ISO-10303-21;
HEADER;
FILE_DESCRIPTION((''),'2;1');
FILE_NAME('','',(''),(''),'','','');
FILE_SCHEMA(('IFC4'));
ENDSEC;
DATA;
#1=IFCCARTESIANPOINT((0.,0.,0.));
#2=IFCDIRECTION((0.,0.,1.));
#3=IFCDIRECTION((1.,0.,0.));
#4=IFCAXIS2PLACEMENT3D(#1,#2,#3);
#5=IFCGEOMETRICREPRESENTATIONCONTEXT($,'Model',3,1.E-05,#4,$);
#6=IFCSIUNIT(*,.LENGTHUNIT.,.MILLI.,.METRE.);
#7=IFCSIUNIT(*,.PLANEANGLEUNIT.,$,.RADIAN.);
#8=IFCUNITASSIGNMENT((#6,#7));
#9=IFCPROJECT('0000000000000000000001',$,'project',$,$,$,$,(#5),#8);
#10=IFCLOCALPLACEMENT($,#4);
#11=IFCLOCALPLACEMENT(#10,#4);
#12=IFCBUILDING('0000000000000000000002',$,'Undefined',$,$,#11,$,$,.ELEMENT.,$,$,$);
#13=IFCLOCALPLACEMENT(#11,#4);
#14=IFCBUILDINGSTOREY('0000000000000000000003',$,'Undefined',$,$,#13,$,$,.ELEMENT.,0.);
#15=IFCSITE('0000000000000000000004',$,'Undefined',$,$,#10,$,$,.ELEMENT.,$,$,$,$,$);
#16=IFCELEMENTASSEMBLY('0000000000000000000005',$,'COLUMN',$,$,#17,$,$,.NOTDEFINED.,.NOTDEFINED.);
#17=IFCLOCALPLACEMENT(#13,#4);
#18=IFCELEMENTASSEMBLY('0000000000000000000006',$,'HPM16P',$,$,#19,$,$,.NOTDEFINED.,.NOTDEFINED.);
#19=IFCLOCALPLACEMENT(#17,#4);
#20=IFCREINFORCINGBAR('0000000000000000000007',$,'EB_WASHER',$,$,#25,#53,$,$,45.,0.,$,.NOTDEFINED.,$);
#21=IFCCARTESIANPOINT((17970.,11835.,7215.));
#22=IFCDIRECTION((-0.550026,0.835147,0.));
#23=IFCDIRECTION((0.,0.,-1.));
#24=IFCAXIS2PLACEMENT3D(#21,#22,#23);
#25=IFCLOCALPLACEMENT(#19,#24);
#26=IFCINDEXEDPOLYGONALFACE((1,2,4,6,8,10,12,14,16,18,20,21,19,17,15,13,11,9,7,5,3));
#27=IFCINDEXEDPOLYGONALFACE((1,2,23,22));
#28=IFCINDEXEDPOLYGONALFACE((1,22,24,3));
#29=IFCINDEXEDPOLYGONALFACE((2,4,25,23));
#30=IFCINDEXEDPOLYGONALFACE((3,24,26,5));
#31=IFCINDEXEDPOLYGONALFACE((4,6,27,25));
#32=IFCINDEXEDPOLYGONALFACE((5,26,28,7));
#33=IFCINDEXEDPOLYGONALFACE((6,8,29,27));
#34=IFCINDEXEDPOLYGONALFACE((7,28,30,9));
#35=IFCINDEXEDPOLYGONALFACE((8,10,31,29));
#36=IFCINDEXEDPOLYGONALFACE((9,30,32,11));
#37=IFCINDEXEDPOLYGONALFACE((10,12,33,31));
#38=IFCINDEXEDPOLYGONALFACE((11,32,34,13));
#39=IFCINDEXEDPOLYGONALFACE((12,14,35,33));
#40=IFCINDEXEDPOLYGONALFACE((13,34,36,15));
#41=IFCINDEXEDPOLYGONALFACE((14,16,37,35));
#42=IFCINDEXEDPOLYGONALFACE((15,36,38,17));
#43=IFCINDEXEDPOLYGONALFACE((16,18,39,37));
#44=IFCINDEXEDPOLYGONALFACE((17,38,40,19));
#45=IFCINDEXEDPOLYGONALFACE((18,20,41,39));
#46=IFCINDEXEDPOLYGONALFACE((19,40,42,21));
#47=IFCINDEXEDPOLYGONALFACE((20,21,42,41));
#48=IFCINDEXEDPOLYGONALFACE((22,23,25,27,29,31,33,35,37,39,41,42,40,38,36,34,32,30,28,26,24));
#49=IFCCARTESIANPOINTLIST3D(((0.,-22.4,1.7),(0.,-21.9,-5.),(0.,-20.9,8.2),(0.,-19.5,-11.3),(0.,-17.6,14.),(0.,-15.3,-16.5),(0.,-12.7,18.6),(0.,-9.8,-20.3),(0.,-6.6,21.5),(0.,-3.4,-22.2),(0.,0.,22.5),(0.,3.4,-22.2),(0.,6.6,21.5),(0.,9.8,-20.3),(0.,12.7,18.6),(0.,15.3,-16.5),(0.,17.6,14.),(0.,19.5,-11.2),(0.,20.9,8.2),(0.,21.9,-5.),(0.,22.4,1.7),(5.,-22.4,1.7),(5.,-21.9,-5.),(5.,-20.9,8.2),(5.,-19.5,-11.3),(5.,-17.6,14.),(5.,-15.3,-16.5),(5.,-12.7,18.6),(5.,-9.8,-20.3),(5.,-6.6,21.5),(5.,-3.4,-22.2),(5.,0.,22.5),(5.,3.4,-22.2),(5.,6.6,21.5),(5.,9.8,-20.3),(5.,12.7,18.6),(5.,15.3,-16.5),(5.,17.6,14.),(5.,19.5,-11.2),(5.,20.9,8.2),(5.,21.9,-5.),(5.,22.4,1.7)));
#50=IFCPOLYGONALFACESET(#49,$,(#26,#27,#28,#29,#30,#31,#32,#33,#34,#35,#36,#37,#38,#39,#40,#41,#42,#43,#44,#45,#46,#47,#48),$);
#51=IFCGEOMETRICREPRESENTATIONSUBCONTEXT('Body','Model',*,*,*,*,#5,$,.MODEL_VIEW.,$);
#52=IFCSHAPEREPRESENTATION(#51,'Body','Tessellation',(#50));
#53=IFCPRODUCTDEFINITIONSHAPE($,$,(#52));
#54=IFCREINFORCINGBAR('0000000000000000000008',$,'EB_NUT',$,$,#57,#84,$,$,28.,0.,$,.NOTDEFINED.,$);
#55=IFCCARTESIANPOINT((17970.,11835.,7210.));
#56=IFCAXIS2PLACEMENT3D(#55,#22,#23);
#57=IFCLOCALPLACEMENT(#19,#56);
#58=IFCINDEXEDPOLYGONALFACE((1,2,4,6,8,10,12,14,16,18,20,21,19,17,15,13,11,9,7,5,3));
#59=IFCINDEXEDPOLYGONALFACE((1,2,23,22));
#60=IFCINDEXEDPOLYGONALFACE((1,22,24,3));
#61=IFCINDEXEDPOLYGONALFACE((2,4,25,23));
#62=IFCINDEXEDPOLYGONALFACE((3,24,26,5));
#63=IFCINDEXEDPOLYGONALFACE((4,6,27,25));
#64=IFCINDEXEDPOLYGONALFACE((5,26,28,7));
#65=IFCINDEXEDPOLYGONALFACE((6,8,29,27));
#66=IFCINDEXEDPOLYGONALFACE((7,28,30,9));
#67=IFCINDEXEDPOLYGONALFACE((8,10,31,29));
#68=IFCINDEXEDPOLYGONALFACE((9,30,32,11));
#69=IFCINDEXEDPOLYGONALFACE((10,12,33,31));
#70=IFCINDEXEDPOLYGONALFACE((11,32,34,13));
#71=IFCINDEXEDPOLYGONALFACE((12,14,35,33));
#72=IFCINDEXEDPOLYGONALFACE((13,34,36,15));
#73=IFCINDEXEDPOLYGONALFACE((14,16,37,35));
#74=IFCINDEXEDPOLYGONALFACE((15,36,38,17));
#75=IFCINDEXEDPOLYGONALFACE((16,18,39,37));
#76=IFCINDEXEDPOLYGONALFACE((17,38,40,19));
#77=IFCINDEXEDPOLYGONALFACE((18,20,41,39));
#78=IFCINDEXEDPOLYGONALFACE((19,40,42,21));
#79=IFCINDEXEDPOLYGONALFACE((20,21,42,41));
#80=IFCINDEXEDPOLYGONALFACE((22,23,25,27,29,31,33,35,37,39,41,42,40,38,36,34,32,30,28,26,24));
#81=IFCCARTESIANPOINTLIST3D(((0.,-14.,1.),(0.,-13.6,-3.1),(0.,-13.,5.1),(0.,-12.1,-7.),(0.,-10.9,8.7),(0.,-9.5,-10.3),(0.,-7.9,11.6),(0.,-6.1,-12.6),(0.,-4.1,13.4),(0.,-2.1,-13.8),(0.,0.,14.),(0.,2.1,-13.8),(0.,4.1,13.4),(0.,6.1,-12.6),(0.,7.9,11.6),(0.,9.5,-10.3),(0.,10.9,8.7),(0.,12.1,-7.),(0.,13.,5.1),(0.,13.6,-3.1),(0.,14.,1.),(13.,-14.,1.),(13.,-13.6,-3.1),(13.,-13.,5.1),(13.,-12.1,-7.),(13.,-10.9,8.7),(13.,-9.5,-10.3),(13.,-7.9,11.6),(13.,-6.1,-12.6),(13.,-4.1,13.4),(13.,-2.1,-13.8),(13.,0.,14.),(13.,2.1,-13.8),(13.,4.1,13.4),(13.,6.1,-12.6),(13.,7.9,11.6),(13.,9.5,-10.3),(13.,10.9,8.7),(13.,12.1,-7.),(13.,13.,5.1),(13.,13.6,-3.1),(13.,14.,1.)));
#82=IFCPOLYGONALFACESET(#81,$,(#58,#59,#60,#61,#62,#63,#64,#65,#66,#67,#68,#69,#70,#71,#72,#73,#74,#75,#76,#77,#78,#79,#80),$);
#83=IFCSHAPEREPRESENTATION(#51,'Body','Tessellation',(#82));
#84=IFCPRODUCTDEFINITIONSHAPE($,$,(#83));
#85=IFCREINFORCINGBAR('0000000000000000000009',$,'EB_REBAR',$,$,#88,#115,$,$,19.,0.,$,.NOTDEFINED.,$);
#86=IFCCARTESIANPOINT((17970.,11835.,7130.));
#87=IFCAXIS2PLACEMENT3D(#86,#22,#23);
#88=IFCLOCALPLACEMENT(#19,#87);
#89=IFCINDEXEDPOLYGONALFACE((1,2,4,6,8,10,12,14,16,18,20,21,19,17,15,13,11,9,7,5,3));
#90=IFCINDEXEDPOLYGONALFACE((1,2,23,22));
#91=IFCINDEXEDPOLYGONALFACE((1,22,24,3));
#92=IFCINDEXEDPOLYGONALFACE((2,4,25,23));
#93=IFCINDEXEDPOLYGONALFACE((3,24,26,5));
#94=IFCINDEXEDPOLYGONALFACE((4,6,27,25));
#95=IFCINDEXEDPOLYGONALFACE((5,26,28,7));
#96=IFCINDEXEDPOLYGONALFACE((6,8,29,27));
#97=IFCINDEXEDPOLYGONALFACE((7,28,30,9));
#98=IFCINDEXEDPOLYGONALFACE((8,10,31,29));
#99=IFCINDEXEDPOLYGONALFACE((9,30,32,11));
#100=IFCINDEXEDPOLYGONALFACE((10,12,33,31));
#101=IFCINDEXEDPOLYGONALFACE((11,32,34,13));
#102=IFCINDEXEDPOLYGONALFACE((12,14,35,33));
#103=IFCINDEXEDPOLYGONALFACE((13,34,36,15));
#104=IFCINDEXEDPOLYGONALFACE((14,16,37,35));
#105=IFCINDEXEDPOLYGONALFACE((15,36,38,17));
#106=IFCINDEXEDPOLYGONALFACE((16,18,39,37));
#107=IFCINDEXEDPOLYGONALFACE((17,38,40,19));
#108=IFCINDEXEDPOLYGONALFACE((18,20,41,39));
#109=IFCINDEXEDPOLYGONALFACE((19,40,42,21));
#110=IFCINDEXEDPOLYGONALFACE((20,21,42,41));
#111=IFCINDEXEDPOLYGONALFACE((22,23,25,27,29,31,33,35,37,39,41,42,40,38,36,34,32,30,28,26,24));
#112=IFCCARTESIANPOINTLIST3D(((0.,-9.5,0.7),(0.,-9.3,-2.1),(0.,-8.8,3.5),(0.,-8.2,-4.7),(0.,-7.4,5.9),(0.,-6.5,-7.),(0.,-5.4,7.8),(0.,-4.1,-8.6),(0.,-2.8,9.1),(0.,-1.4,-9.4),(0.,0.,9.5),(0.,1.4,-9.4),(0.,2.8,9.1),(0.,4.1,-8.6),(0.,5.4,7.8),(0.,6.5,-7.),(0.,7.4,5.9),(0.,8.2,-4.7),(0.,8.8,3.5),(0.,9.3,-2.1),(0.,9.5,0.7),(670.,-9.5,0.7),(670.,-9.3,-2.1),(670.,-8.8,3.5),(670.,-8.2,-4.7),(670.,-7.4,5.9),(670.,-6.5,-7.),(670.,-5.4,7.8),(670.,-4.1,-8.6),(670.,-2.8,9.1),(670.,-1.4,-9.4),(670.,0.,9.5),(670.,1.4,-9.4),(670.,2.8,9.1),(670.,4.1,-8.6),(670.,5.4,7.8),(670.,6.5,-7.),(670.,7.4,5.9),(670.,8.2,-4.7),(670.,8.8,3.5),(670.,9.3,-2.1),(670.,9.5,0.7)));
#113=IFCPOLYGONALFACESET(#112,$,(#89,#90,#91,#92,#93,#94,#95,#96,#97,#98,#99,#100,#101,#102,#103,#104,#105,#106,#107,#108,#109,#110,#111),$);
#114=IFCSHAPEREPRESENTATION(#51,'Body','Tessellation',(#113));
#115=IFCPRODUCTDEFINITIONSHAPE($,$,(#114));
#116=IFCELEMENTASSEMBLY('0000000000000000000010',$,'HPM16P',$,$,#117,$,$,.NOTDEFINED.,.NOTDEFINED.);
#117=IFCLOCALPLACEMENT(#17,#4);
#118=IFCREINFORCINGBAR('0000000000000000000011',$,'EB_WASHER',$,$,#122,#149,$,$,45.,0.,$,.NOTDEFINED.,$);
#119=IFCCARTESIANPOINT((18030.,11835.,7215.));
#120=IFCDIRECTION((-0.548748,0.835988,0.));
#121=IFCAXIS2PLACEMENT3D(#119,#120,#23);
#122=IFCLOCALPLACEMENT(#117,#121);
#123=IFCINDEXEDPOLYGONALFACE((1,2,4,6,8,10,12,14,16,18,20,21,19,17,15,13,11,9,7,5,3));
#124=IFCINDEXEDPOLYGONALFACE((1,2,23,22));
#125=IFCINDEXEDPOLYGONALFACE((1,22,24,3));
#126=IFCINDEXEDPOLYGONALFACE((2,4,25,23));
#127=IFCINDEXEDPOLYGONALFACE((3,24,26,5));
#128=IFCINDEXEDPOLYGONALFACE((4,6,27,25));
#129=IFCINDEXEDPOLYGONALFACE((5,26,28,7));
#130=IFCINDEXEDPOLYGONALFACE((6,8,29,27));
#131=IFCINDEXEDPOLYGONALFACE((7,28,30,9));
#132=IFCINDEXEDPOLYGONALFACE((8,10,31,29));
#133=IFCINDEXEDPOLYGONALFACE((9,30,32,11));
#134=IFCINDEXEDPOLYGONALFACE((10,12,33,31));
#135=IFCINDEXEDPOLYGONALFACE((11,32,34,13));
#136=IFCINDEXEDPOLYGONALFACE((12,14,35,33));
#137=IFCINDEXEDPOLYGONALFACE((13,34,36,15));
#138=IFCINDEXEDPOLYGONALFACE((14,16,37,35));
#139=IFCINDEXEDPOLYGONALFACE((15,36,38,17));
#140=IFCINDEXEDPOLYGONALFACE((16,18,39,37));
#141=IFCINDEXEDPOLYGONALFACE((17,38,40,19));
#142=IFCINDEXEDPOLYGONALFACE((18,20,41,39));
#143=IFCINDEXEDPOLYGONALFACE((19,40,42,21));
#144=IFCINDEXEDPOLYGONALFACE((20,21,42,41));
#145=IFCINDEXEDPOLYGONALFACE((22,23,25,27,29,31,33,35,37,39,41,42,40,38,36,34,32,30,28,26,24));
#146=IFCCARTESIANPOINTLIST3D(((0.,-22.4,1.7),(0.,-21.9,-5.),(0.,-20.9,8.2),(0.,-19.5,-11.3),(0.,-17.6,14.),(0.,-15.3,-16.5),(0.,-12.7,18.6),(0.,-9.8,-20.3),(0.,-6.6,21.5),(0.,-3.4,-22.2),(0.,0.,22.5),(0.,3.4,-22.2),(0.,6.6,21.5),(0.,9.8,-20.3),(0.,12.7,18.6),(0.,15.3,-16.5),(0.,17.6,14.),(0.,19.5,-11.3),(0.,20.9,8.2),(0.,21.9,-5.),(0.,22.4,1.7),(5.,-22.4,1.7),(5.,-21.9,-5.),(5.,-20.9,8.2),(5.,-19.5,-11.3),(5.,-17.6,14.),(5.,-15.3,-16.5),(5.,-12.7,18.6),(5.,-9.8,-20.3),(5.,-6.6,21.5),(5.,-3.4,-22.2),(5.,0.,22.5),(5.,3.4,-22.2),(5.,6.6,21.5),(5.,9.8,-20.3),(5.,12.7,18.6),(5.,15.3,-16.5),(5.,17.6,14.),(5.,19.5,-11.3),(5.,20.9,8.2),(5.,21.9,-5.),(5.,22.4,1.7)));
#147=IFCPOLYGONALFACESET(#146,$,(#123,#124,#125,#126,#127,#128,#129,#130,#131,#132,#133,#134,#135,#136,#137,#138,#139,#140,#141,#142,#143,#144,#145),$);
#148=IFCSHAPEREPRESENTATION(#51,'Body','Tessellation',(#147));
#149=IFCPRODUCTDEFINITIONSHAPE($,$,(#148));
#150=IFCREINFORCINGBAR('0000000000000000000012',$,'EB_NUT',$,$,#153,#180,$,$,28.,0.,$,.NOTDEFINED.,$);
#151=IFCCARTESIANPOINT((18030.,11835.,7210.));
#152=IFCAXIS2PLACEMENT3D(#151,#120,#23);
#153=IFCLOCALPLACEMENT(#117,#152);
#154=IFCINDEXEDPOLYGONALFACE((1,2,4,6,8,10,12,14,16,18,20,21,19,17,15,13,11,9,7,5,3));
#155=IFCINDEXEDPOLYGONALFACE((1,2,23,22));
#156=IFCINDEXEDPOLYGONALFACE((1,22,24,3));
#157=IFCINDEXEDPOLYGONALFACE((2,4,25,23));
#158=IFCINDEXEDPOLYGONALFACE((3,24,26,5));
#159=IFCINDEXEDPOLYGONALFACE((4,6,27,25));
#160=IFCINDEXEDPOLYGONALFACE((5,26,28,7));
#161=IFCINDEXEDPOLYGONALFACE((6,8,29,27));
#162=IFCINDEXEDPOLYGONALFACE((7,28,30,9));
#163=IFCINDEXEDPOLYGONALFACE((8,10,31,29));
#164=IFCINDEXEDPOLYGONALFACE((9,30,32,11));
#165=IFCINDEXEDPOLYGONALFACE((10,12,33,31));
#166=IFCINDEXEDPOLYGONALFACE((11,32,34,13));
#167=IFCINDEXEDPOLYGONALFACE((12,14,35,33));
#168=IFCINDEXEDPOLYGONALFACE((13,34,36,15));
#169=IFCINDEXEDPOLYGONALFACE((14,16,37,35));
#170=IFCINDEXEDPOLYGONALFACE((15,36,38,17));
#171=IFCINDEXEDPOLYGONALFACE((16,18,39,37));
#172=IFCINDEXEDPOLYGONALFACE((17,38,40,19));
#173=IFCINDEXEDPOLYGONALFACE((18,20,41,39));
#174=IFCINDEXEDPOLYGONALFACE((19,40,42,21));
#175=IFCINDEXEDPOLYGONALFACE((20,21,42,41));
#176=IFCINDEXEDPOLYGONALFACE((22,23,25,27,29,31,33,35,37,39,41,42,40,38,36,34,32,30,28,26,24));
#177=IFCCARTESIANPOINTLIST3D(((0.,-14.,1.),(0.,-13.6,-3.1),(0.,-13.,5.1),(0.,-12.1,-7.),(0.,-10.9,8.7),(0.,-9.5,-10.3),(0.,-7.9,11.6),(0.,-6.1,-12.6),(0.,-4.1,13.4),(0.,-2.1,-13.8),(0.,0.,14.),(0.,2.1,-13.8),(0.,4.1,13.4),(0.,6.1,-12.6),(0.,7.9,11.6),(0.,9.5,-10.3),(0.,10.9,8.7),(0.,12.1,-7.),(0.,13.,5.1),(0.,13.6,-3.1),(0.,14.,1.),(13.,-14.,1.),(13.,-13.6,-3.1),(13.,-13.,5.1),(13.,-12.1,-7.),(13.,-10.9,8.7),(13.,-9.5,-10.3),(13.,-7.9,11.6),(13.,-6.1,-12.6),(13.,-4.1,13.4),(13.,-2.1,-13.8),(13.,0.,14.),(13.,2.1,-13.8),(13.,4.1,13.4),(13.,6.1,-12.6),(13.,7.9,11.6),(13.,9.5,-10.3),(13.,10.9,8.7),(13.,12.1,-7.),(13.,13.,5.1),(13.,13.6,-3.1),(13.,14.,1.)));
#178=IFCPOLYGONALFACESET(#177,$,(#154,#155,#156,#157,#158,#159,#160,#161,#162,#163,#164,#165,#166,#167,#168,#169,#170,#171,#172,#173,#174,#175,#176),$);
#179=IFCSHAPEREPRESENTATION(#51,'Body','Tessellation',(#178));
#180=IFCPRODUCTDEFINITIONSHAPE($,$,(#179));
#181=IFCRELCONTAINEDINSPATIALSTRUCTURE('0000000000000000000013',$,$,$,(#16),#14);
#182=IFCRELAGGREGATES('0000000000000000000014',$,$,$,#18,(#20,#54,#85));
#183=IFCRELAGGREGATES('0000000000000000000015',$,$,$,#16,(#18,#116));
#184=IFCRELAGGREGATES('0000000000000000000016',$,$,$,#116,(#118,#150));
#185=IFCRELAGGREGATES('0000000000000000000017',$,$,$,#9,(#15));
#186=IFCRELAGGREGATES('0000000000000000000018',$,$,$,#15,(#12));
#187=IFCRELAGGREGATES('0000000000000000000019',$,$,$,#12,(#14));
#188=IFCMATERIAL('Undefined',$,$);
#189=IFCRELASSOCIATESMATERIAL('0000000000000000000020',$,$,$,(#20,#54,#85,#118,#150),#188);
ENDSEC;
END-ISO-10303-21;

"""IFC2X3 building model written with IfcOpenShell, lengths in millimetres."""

from ifc_helpers import new_model, entity, si_unit, frame, origin_with_axes, place, context, subcontext, project, spatial, source, transform, mapped, material, element, aggregate, save


model = new_model("IFC2X3")

# Units and contexts
model_context = context("Model", 3, precision=1e-05, world=origin_with_axes())
body_context = subcontext(model_context, "Body", "Model", "MODEL_VIEW")
ifc_project = project(units=[si_unit("LENGTHUNIT", "METRE", prefix="MILLI"), si_unit("PLANEANGLEUNIT", "RADIAN")], contexts=[model_context])

# Site, building, storey
site_placement = place(None, origin_with_axes())
site = spatial("IfcSite", under=ifc_project, at=site_placement, Name="Undefined", CompositionType="ELEMENT")
building_placement = place(site_placement, origin_with_axes())
building = spatial("IfcBuilding", under=site, at=building_placement, Name="Undefined", CompositionType="ELEMENT")
storey_placement = place(building_placement, origin_with_axes())
storey = spatial("IfcBuildingStorey", under=building, at=storey_placement, Name="Undefined", CompositionType="ELEMENT", Elevation=0.0)

# Element assembly
assembly_1_placement = place(storey_placement, origin_with_axes())
assembly_1 = element("IfcElementAssembly", 1, at=assembly_1_placement, inside=storey, Name="COLUMN", AssemblyPlace="NOTDEFINED", PredefinedType="NOTDEFINED")

# Shared definitions
ifc_material_1 = material(Name="Undefined")

# Element assembly, reinforcing bars
assembly_2_placement = place(assembly_1_placement, origin_with_axes())
assembly_2 = element("IfcElementAssembly", 2, at=assembly_2_placement, Name="HPM16P", AssemblyPlace="NOTDEFINED", PredefinedType="NOTDEFINED")
shared_shape_1 = source(origin_with_axes(), body_context, "Body", "AdvancedSweptSolid", [
    entity("IfcSweptDiskSolid", entity("IfcTrimmedCurve", entity("IfcLine", entity("IfcCartesianPoint", [0.0, 0.0, 0.0]), entity("IfcVector", entity("IfcDirection", [1.0, 0.0, 0.0]), 1.0)), [entity("IfcParameterValue", 0.0)], [entity("IfcParameterValue", 5.0)], True, "PARAMETER"), 22.5, None, 0.0, 5.0),
])
reinforcing_bar_1_placement = place(assembly_2_placement, frame((17970.0, 11835.0, 7215.0), z_axis=(-0.550026, 0.835147, 0.0), x_axis=(0.0, 0.0, -1.0)))
reinforcing_bar_1 = element("IfcReinforcingBar", 3, at=reinforcing_bar_1_placement, material=ifc_material_1, Name="EB_WASHER", BarRole="NOTDEFINED", CrossSectionArea=0.0, NominalDiameter=45.0, context=body_context, shape_type="MappedRepresentation", body=[
    mapped(shared_shape_1, transform((0.0, 0.0, 0.0))),
])
shared_shape_2 = source(origin_with_axes(), body_context, "Body", "AdvancedSweptSolid", [
    entity("IfcSweptDiskSolid", entity("IfcTrimmedCurve", entity("IfcLine", entity("IfcCartesianPoint", [0.0, 0.0, 0.0]), entity("IfcVector", entity("IfcDirection", [1.0, 0.0, 0.0]), 1.0)), [entity("IfcParameterValue", 0.0)], [entity("IfcParameterValue", 13.0)], True, "PARAMETER"), 14.0, None, 0.0, 13.0),
])
reinforcing_bar_2_placement = place(assembly_2_placement, frame((17970.0, 11835.0, 7210.0), z_axis=(-0.550026, 0.835147, 0.0), x_axis=(0.0, 0.0, -1.0)))
reinforcing_bar_2 = element("IfcReinforcingBar", 4, at=reinforcing_bar_2_placement, material=ifc_material_1, Name="EB_NUT", BarRole="NOTDEFINED", CrossSectionArea=0.0, NominalDiameter=28.0, context=body_context, shape_type="MappedRepresentation", body=[
    mapped(shared_shape_2, transform((0.0, 0.0, 0.0))),
])
shared_shape_3 = source(origin_with_axes(), body_context, "Body", "AdvancedSweptSolid", [
    entity("IfcSweptDiskSolid", entity("IfcTrimmedCurve", entity("IfcLine", entity("IfcCartesianPoint", [0.0, 0.0, 0.0]), entity("IfcVector", entity("IfcDirection", [1.0, 0.0, 0.0]), 1.0)), [entity("IfcParameterValue", 0.0)], [entity("IfcParameterValue", 670.0)], True, "PARAMETER"), 9.5, None, 0.0, 670.0),
])
reinforcing_bar_3_placement = place(assembly_2_placement, frame((17970.0, 11835.0, 7130.0), z_axis=(-0.550026, 0.835147, 0.0), x_axis=(0.0, 0.0, -1.0)))
reinforcing_bar_3 = element("IfcReinforcingBar", 5, at=reinforcing_bar_3_placement, material=ifc_material_1, Name="EB_REBAR", BarRole="NOTDEFINED", CrossSectionArea=0.0, NominalDiameter=19.0, context=body_context, shape_type="MappedRepresentation", body=[
    mapped(shared_shape_3, transform((0.0, 0.0, 0.0))),
])
aggregate(assembly_2, [reinforcing_bar_1, reinforcing_bar_2, reinforcing_bar_3])

# Element assembly
assembly_3_placement = place(assembly_1_placement, origin_with_axes())
assembly_3 = element("IfcElementAssembly", 6, at=assembly_3_placement, Name="HPM16P", AssemblyPlace="NOTDEFINED", PredefinedType="NOTDEFINED")
aggregate(assembly_1, [assembly_2, assembly_3])

# Reinforcing bars
shared_shape_4 = source(origin_with_axes(), body_context, "Body", "AdvancedSweptSolid", [
    entity("IfcSweptDiskSolid", entity("IfcTrimmedCurve", entity("IfcLine", entity("IfcCartesianPoint", [0.0, 0.0, 0.0]), entity("IfcVector", entity("IfcDirection", [1.0, 0.0, 0.0]), 1.0)), [entity("IfcParameterValue", 0.0)], [entity("IfcParameterValue", 5.0)], True, "PARAMETER"), 22.5, None, 0.0, 5.0),
])
reinforcing_bar_4_placement = place(assembly_3_placement, frame((18030.0, 11835.0, 7215.0), z_axis=(-0.548748, 0.835988, 0.0), x_axis=(0.0, 0.0, -1.0)))
reinforcing_bar_4 = element("IfcReinforcingBar", 7, at=reinforcing_bar_4_placement, material=ifc_material_1, Name="EB_WASHER", BarRole="NOTDEFINED", CrossSectionArea=0.0, NominalDiameter=45.0, context=body_context, shape_type="MappedRepresentation", body=[
    mapped(shared_shape_4, transform((0.0, 0.0, 0.0))),
])
shared_shape_5 = source(origin_with_axes(), body_context, "Body", "AdvancedSweptSolid", [
    entity("IfcSweptDiskSolid", entity("IfcTrimmedCurve", entity("IfcLine", entity("IfcCartesianPoint", [0.0, 0.0, 0.0]), entity("IfcVector", entity("IfcDirection", [1.0, 0.0, 0.0]), 1.0)), [entity("IfcParameterValue", 0.0)], [entity("IfcParameterValue", 13.0)], True, "PARAMETER"), 14.0, None, 0.0, 13.0),
])
reinforcing_bar_5_placement = place(assembly_3_placement, frame((18030.0, 11835.0, 7210.0), z_axis=(-0.548748, 0.835988, 0.0), x_axis=(0.0, 0.0, -1.0)))
reinforcing_bar_5 = element("IfcReinforcingBar", 8, at=reinforcing_bar_5_placement, material=ifc_material_1, Name="EB_NUT", BarRole="NOTDEFINED", CrossSectionArea=0.0, NominalDiameter=28.0, context=body_context, shape_type="MappedRepresentation", body=[
    mapped(shared_shape_5, transform((0.0, 0.0, 0.0))),
])
aggregate(assembly_3, [reinforcing_bar_4, reinforcing_bar_5])

save(model, "model.ifc")
